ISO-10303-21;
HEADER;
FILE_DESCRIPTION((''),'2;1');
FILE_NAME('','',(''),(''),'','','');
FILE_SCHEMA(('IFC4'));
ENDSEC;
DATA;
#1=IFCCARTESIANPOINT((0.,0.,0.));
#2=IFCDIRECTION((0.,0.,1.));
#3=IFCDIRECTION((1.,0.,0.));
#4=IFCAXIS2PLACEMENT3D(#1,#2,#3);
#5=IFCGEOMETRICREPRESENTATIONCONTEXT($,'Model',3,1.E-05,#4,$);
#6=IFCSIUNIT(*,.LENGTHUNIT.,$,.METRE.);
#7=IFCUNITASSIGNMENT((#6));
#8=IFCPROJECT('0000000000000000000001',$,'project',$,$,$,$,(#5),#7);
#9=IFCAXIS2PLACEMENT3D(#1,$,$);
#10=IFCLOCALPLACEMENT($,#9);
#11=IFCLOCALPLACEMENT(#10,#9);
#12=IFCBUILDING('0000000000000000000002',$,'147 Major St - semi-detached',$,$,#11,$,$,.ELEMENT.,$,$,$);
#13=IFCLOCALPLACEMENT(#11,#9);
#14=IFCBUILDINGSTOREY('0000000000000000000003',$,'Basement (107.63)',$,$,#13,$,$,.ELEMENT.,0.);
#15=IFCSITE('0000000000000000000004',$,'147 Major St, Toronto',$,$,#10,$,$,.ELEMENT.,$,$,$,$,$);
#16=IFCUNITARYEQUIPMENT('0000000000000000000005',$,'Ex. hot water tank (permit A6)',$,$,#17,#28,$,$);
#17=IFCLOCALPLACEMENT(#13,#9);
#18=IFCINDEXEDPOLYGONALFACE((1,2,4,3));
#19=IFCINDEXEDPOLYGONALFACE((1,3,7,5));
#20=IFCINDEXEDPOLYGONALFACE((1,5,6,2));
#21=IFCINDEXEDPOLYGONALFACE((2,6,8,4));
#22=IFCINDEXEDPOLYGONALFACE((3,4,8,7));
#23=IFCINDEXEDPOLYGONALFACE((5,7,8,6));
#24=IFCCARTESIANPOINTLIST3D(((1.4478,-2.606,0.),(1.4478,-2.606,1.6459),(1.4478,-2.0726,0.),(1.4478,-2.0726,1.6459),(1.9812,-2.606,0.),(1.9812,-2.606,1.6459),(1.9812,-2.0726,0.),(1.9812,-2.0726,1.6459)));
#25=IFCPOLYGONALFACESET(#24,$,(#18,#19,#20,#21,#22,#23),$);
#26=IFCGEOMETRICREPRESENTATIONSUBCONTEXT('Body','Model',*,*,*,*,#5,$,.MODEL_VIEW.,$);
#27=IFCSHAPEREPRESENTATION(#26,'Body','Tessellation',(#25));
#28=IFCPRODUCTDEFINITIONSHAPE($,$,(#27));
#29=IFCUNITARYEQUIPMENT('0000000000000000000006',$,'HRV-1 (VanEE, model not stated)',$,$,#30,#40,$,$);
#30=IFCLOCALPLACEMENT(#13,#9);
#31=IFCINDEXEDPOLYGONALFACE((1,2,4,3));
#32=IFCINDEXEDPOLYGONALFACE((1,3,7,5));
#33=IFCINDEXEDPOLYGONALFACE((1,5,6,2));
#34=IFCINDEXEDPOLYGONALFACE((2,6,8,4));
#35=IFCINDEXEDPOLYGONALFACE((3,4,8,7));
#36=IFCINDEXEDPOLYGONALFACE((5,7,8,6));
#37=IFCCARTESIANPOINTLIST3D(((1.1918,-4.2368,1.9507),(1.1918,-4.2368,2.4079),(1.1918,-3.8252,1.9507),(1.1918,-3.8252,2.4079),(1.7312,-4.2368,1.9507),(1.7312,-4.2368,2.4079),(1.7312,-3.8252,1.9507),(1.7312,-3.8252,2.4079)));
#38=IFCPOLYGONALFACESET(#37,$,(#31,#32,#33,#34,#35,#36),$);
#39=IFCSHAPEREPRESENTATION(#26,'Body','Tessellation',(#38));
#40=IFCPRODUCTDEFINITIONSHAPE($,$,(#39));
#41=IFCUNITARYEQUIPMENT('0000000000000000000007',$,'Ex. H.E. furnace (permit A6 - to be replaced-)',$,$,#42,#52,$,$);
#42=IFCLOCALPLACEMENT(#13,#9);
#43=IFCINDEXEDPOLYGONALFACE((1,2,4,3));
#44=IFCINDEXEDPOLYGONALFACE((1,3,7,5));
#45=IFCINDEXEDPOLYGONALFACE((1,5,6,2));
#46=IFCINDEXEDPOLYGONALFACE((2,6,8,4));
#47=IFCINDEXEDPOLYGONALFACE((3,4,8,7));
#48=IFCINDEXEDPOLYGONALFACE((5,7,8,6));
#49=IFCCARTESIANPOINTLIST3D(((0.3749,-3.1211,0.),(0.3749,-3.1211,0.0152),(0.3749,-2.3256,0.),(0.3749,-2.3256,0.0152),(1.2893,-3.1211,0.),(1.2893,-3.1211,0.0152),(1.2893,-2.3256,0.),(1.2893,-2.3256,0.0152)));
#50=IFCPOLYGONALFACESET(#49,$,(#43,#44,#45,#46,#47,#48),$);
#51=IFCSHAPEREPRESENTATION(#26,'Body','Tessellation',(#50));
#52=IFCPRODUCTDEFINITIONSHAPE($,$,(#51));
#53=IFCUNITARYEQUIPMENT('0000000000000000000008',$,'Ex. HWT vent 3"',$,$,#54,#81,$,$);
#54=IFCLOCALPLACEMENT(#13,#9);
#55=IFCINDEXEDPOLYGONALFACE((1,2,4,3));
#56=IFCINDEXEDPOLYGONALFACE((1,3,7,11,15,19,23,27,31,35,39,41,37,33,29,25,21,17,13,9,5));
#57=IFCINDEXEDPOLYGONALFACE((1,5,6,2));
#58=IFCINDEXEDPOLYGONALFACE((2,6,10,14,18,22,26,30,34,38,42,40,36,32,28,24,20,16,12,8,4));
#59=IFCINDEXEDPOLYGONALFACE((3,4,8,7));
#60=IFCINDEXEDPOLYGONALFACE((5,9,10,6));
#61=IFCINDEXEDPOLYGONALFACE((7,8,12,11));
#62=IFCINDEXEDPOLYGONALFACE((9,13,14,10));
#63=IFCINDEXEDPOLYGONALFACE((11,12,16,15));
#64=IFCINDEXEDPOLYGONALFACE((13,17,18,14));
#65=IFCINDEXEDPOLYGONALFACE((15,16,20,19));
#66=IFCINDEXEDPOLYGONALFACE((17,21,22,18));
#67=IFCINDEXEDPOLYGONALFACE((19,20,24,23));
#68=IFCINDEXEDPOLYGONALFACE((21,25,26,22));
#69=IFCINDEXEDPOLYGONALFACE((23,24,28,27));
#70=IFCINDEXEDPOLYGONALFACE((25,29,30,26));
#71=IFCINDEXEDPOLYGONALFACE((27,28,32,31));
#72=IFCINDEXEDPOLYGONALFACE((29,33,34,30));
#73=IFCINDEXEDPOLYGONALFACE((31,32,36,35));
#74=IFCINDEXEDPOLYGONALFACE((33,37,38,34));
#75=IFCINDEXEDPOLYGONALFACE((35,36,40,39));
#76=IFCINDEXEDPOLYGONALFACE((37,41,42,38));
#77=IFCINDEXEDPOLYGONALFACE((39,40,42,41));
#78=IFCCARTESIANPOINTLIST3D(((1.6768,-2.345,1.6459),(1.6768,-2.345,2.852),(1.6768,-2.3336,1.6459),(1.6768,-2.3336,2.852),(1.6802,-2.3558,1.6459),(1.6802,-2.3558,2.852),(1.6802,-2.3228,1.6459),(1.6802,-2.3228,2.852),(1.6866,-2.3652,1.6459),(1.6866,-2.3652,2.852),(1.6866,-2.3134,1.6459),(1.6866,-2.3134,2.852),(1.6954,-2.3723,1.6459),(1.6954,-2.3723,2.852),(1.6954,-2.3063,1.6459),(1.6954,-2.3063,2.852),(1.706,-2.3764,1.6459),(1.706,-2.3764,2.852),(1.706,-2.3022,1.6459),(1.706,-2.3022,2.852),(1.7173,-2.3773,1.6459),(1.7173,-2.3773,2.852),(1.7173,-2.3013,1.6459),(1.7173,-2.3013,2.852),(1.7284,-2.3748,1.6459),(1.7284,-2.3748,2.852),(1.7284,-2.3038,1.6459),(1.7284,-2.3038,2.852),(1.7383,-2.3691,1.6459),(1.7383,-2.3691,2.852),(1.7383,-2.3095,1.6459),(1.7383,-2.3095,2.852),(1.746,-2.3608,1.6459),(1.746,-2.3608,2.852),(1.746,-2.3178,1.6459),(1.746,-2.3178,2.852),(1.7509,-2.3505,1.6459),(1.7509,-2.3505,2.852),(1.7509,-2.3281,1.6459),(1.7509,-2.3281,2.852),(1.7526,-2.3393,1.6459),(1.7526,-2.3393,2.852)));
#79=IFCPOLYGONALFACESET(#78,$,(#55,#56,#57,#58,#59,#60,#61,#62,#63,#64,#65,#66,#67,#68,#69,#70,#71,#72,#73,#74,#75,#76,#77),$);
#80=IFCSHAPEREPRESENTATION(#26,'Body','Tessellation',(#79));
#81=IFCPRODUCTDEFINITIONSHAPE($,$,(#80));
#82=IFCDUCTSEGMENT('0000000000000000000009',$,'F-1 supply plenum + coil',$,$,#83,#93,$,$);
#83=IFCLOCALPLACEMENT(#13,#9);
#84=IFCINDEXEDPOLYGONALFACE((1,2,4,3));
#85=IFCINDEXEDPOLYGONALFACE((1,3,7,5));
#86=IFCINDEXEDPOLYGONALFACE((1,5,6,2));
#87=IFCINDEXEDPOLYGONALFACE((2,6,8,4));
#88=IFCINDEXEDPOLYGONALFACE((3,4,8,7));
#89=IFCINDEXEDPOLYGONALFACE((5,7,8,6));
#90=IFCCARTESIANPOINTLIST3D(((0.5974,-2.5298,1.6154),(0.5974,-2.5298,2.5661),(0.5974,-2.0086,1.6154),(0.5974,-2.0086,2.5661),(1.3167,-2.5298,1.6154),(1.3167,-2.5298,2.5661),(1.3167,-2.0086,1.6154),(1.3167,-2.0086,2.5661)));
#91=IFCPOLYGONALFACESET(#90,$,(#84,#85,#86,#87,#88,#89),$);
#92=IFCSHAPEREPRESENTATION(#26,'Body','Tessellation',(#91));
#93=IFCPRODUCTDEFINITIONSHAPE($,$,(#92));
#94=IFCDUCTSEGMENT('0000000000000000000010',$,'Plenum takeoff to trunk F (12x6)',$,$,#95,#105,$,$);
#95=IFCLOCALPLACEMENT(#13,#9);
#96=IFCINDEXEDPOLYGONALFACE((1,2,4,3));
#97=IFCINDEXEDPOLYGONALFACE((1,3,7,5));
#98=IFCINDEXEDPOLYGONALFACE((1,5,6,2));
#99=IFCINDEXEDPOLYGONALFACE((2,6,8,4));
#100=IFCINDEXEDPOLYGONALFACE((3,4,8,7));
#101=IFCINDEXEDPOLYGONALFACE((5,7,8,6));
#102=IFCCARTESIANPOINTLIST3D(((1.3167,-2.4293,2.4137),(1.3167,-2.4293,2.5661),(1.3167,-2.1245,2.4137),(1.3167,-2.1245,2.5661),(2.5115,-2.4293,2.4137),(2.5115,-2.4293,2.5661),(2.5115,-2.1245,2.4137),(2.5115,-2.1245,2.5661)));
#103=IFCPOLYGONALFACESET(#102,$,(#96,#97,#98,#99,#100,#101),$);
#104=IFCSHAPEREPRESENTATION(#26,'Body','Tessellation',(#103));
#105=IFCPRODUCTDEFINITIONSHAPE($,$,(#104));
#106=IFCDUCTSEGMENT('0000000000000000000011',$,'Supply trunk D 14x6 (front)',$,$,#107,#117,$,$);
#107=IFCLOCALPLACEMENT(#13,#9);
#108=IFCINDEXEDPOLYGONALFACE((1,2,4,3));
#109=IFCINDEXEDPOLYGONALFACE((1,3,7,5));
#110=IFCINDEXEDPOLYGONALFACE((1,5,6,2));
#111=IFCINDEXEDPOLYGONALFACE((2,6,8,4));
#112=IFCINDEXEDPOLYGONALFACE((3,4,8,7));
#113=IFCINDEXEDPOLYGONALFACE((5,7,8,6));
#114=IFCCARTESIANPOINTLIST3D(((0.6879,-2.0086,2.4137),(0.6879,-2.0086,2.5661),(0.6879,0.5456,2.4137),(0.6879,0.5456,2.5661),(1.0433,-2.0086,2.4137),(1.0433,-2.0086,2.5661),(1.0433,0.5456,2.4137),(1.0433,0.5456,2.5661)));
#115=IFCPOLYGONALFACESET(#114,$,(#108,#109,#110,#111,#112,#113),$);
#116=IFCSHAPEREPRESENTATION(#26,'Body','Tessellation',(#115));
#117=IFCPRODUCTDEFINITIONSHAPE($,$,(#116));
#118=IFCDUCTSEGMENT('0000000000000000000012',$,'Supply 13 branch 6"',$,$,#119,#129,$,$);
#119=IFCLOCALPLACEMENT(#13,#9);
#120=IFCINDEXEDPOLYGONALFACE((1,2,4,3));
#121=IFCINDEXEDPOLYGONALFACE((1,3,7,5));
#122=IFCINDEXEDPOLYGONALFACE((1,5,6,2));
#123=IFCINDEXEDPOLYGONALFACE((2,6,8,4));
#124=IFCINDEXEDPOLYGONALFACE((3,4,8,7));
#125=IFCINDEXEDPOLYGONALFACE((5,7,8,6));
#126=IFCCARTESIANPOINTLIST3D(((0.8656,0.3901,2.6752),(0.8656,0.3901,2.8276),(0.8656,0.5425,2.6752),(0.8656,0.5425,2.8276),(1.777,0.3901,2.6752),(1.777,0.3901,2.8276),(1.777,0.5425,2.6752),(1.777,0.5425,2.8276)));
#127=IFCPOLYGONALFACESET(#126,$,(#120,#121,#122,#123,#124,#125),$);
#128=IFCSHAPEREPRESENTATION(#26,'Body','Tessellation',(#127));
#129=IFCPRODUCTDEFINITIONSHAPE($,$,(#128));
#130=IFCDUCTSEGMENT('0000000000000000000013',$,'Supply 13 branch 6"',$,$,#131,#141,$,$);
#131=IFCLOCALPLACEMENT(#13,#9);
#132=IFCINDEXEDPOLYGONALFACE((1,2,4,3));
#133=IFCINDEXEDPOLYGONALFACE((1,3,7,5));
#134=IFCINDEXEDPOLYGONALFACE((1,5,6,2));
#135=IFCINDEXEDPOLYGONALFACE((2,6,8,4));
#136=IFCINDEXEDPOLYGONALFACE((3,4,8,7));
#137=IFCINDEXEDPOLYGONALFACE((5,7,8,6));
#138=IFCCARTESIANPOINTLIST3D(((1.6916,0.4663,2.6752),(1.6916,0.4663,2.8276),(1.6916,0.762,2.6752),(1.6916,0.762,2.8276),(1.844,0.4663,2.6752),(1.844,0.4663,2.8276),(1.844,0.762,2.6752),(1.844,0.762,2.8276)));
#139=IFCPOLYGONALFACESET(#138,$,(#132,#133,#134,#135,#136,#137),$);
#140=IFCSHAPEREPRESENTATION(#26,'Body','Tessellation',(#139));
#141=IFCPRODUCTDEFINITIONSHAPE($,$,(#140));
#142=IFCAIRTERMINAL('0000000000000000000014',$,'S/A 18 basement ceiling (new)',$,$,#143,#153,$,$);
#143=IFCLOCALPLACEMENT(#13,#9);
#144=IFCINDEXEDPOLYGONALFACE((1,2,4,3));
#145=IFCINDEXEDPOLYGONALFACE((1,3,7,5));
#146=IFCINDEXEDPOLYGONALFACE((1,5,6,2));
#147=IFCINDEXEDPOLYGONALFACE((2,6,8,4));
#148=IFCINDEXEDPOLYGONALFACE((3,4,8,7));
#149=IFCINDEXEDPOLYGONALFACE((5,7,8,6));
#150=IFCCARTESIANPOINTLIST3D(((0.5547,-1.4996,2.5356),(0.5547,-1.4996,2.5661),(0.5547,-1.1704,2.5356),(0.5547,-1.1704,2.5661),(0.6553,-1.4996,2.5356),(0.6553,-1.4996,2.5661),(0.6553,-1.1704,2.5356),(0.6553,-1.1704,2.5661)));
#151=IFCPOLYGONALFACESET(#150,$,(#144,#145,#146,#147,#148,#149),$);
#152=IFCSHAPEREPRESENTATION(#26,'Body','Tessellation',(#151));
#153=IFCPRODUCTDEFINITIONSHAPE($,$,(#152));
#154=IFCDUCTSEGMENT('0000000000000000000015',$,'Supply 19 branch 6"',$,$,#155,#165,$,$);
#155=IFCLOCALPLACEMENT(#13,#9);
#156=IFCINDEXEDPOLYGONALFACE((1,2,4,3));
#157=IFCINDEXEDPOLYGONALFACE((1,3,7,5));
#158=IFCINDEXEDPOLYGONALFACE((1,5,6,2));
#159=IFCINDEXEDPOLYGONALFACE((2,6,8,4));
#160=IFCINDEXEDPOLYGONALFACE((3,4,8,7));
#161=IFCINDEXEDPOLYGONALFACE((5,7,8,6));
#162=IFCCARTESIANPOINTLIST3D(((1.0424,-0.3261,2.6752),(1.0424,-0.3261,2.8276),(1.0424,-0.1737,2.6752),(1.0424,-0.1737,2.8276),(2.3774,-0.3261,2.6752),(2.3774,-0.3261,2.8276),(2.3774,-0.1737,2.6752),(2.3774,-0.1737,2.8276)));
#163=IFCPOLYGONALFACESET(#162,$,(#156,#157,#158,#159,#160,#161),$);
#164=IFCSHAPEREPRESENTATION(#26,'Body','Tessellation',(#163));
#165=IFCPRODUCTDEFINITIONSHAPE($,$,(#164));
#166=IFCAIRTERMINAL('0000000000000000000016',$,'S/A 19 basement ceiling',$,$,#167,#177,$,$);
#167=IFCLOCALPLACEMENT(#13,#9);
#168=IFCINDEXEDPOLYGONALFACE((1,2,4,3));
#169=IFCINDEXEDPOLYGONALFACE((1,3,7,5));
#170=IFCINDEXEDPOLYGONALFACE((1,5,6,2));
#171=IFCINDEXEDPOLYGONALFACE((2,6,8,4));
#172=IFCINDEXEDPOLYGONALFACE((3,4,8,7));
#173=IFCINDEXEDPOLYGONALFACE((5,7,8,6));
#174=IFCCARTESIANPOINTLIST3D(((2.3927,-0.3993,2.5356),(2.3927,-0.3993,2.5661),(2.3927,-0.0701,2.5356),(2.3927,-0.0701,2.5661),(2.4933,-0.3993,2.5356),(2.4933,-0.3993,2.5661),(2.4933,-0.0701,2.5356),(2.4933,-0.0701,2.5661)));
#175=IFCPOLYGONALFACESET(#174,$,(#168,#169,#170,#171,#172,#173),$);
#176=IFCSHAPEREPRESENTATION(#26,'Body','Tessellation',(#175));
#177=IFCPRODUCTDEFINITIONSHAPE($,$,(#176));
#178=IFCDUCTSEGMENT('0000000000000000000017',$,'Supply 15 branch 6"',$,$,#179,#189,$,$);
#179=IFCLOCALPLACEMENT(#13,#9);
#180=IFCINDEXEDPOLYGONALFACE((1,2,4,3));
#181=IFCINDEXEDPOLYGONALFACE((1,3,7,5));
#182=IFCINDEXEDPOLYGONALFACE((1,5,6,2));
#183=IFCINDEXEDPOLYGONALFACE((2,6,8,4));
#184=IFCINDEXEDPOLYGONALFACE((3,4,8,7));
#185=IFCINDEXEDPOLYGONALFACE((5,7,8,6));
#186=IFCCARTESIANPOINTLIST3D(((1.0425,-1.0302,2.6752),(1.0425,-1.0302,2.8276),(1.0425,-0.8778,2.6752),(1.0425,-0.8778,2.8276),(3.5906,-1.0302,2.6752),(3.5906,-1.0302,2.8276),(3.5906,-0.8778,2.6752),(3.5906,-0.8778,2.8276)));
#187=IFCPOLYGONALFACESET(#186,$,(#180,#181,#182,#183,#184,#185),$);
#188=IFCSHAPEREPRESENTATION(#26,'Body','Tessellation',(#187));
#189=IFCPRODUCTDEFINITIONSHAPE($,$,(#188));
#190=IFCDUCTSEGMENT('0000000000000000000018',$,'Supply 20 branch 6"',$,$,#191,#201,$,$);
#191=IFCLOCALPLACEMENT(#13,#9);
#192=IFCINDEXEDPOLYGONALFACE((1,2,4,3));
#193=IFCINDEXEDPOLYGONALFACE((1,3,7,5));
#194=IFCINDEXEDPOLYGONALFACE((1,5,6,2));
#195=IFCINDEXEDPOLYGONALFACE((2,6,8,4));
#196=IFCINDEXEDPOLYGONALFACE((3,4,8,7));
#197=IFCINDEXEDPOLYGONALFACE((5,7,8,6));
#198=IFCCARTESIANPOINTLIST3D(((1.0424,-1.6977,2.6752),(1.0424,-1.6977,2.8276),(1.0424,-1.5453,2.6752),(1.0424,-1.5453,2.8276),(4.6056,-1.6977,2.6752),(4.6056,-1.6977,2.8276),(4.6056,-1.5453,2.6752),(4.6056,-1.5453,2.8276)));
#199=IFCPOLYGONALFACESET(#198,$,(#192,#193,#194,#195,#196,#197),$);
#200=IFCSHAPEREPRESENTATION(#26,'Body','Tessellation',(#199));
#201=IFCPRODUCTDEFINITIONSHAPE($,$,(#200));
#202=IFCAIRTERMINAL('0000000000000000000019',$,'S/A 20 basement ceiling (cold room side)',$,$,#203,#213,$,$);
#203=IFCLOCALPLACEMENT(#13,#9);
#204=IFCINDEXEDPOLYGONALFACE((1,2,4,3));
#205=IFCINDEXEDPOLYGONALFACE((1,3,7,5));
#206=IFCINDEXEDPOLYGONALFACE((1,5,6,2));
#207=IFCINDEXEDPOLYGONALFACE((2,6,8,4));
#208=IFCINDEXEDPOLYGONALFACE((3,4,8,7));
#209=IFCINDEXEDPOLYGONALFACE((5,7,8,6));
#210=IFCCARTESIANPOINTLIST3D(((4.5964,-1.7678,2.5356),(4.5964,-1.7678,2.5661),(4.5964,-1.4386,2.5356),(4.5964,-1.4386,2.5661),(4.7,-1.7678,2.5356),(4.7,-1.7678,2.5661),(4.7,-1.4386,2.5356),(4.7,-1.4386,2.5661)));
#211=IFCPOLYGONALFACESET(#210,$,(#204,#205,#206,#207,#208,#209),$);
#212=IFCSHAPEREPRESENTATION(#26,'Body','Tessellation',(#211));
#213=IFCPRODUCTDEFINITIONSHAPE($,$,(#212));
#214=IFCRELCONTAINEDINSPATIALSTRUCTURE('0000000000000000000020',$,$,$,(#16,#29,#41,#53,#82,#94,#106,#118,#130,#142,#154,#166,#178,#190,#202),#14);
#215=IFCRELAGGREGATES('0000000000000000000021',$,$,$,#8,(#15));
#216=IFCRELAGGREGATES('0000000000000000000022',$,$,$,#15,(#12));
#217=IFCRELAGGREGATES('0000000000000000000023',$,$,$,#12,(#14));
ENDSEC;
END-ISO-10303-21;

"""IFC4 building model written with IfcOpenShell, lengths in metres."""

from ifc_helpers import new_model, si_unit, frame, origin, origin_with_axes, place, context, subcontext, project, spatial, rectangle, circle, extrude, element, save


model = new_model("IFC4")

# Units and contexts
model_context = context("Model", 3, precision=1e-05, world=origin_with_axes())
body_context = subcontext(model_context, "Body", "Model", "MODEL_VIEW")
ifc_project = project(units=[si_unit("LENGTHUNIT", "METRE")], contexts=[model_context])

# Site, building, storey
site_placement = place(None, origin())
site = spatial("IfcSite", under=ifc_project, at=site_placement, Name="147 Major St, Toronto", CompositionType="ELEMENT")
building_placement = place(site_placement, origin())
building = spatial("IfcBuilding", under=site, at=building_placement, Name="147 Major St - semi-detached", CompositionType="ELEMENT")
storey_placement = place(building_placement, origin())
storey = spatial("IfcBuildingStorey", under=building, at=storey_placement, Name="Basement (107.63)", CompositionType="ELEMENT", Elevation=0.0)

# Unitary equipment
unitary_equipment_1_placement = place(storey_placement, frame((1.7145, -2.3393, 0.0)))
element("IfcUnitaryEquipment", 1, at=unitary_equipment_1_placement, inside=storey, Name="Ex. hot water tank (permit A6)", context=body_context, shape_type="SweptSolid", body=[
    extrude(rectangle(XDim=0.5334, YDim=0.5334), origin_with_axes(), (0.0, 0.0, 1.0), 1.6459),
])
unitary_equipment_2_placement = place(storey_placement, frame((1.4615, -4.031, 1.9507)))
element("IfcUnitaryEquipment", 2, at=unitary_equipment_2_placement, inside=storey, Name="HRV-1 (VanEE, model not stated)", context=body_context, shape_type="SweptSolid", body=[
    extrude(rectangle(XDim=0.5395, YDim=0.4115), origin_with_axes(), (0.0, 0.0, 1.0), 0.4572),
])
unitary_equipment_3_placement = place(storey_placement, frame((0.8321, -2.7234, 0.0)))
element("IfcUnitaryEquipment", 3, at=unitary_equipment_3_placement, inside=storey, Name="Ex. H.E. furnace (permit A6 - to be replaced-)", context=body_context, shape_type="SweptSolid", body=[
    extrude(rectangle(XDim=0.9144, YDim=0.7955), origin_with_axes(), (0.0, 0.0, 1.0), 0.0152),
])
unitary_equipment_4_placement = place(storey_placement, frame((1.7145, -2.3393, 1.6459)))
element("IfcUnitaryEquipment", 4, at=unitary_equipment_4_placement, inside=storey, Name="Ex. HWT vent 3\"", context=body_context, shape_type="SweptSolid", body=[
    extrude(circle(Radius=0.0381), origin_with_axes(), (0.0, 0.0, 1.0), 1.2061),
])

# Duct segments
duct_segment_1_placement = place(storey_placement, frame((0.9571, -2.2692, 1.6154)))
element("IfcDuctSegment", 5, at=duct_segment_1_placement, inside=storey, Name="F-1 supply plenum + coil", context=body_context, shape_type="SweptSolid", body=[
    extrude(rectangle(XDim=0.7193, YDim=0.5212), origin_with_axes(), (0.0, 0.0, 1.0), 0.9507),
])
duct_segment_2_placement = place(storey_placement, frame((1.9141, -2.2769, 2.4137)))
element("IfcDuctSegment", 6, at=duct_segment_2_placement, inside=storey, Name="Plenum takeoff to trunk F (12x6)", context=body_context, shape_type="SweptSolid", body=[
    extrude(rectangle(XDim=1.1948, YDim=0.3048), origin_with_axes(), (0.0, 0.0, 1.0), 0.1524),
])
duct_segment_3_placement = place(storey_placement, frame((0.8656, -0.7315, 2.4137)))
element("IfcDuctSegment", 7, at=duct_segment_3_placement, inside=storey, Name="Supply trunk D 14x6 (front)", context=body_context, shape_type="SweptSolid", body=[
    extrude(rectangle(XDim=0.3554, YDim=2.5542), origin_with_axes(), (0.0, 0.0, 1.0), 0.1524),
])
duct_segment_4_placement = place(storey_placement, frame((1.3213, 0.4663, 2.6752)))
element("IfcDuctSegment", 8, at=duct_segment_4_placement, inside=storey, Name="Supply 13 branch 6\"", context=body_context, shape_type="SweptSolid", body=[
    extrude(rectangle(XDim=0.9114, YDim=0.1524), origin_with_axes(), (0.0, 0.0, 1.0), 0.1524),
])
duct_segment_5_placement = place(storey_placement, frame((1.7678, 0.6142, 2.6752)))
element("IfcDuctSegment", 9, at=duct_segment_5_placement, inside=storey, Name="Supply 13 branch 6\"", context=body_context, shape_type="SweptSolid", body=[
    extrude(rectangle(XDim=0.1524, YDim=0.2957), origin_with_axes(), (0.0, 0.0, 1.0), 0.1524),
])

# Air terminal
air_terminal_1_placement = place(storey_placement, frame((0.605, -1.335, 2.5356)))
element("IfcAirTerminal", 10, at=air_terminal_1_placement, inside=storey, Name="S/A 18 basement ceiling (new)", context=body_context, shape_type="SweptSolid", body=[
    extrude(rectangle(XDim=0.1006, YDim=0.3292), origin_with_axes(), (0.0, 0.0, 1.0), 0.0305),
])

# Duct segment
duct_segment_6_placement = place(storey_placement, frame((1.7099, -0.2499, 2.6752)))
element("IfcDuctSegment", 11, at=duct_segment_6_placement, inside=storey, Name="Supply 19 branch 6\"", context=body_context, shape_type="SweptSolid", body=[
    extrude(rectangle(XDim=1.335, YDim=0.1524), origin_with_axes(), (0.0, 0.0, 1.0), 0.1524),
])

# Air terminal
air_terminal_2_placement = place(storey_placement, frame((2.443, -0.2347, 2.5356)))
element("IfcAirTerminal", 12, at=air_terminal_2_placement, inside=storey, Name="S/A 19 basement ceiling", context=body_context, shape_type="SweptSolid", body=[
    extrude(rectangle(XDim=0.1006, YDim=0.3292), origin_with_axes(), (0.0, 0.0, 1.0), 0.0305),
])

# Duct segments
duct_segment_7_placement = place(storey_placement, frame((2.3165, -0.954, 2.6752)))
element("IfcDuctSegment", 13, at=duct_segment_7_placement, inside=storey, Name="Supply 15 branch 6\"", context=body_context, shape_type="SweptSolid", body=[
    extrude(rectangle(XDim=2.5481, YDim=0.1524), origin_with_axes(), (0.0, 0.0, 1.0), 0.1524),
])
duct_segment_8_placement = place(storey_placement, frame((2.824, -1.6215, 2.6752)))
element("IfcDuctSegment", 14, at=duct_segment_8_placement, inside=storey, Name="Supply 20 branch 6\"", context=body_context, shape_type="SweptSolid", body=[
    extrude(rectangle(XDim=3.5631, YDim=0.1524), origin_with_axes(), (0.0, 0.0, 1.0), 0.1524),
])

# Air terminal
air_terminal_3_placement = place(storey_placement, frame((4.6482, -1.6032, 2.5356)))
element("IfcAirTerminal", 15, at=air_terminal_3_placement, inside=storey, Name="S/A 20 basement ceiling (cold room side)", context=body_context, shape_type="SweptSolid", body=[
    extrude(rectangle(XDim=0.1036, YDim=0.3292), origin_with_axes(), (0.0, 0.0, 1.0), 0.0305),
])

save(model, "model.ifc")
